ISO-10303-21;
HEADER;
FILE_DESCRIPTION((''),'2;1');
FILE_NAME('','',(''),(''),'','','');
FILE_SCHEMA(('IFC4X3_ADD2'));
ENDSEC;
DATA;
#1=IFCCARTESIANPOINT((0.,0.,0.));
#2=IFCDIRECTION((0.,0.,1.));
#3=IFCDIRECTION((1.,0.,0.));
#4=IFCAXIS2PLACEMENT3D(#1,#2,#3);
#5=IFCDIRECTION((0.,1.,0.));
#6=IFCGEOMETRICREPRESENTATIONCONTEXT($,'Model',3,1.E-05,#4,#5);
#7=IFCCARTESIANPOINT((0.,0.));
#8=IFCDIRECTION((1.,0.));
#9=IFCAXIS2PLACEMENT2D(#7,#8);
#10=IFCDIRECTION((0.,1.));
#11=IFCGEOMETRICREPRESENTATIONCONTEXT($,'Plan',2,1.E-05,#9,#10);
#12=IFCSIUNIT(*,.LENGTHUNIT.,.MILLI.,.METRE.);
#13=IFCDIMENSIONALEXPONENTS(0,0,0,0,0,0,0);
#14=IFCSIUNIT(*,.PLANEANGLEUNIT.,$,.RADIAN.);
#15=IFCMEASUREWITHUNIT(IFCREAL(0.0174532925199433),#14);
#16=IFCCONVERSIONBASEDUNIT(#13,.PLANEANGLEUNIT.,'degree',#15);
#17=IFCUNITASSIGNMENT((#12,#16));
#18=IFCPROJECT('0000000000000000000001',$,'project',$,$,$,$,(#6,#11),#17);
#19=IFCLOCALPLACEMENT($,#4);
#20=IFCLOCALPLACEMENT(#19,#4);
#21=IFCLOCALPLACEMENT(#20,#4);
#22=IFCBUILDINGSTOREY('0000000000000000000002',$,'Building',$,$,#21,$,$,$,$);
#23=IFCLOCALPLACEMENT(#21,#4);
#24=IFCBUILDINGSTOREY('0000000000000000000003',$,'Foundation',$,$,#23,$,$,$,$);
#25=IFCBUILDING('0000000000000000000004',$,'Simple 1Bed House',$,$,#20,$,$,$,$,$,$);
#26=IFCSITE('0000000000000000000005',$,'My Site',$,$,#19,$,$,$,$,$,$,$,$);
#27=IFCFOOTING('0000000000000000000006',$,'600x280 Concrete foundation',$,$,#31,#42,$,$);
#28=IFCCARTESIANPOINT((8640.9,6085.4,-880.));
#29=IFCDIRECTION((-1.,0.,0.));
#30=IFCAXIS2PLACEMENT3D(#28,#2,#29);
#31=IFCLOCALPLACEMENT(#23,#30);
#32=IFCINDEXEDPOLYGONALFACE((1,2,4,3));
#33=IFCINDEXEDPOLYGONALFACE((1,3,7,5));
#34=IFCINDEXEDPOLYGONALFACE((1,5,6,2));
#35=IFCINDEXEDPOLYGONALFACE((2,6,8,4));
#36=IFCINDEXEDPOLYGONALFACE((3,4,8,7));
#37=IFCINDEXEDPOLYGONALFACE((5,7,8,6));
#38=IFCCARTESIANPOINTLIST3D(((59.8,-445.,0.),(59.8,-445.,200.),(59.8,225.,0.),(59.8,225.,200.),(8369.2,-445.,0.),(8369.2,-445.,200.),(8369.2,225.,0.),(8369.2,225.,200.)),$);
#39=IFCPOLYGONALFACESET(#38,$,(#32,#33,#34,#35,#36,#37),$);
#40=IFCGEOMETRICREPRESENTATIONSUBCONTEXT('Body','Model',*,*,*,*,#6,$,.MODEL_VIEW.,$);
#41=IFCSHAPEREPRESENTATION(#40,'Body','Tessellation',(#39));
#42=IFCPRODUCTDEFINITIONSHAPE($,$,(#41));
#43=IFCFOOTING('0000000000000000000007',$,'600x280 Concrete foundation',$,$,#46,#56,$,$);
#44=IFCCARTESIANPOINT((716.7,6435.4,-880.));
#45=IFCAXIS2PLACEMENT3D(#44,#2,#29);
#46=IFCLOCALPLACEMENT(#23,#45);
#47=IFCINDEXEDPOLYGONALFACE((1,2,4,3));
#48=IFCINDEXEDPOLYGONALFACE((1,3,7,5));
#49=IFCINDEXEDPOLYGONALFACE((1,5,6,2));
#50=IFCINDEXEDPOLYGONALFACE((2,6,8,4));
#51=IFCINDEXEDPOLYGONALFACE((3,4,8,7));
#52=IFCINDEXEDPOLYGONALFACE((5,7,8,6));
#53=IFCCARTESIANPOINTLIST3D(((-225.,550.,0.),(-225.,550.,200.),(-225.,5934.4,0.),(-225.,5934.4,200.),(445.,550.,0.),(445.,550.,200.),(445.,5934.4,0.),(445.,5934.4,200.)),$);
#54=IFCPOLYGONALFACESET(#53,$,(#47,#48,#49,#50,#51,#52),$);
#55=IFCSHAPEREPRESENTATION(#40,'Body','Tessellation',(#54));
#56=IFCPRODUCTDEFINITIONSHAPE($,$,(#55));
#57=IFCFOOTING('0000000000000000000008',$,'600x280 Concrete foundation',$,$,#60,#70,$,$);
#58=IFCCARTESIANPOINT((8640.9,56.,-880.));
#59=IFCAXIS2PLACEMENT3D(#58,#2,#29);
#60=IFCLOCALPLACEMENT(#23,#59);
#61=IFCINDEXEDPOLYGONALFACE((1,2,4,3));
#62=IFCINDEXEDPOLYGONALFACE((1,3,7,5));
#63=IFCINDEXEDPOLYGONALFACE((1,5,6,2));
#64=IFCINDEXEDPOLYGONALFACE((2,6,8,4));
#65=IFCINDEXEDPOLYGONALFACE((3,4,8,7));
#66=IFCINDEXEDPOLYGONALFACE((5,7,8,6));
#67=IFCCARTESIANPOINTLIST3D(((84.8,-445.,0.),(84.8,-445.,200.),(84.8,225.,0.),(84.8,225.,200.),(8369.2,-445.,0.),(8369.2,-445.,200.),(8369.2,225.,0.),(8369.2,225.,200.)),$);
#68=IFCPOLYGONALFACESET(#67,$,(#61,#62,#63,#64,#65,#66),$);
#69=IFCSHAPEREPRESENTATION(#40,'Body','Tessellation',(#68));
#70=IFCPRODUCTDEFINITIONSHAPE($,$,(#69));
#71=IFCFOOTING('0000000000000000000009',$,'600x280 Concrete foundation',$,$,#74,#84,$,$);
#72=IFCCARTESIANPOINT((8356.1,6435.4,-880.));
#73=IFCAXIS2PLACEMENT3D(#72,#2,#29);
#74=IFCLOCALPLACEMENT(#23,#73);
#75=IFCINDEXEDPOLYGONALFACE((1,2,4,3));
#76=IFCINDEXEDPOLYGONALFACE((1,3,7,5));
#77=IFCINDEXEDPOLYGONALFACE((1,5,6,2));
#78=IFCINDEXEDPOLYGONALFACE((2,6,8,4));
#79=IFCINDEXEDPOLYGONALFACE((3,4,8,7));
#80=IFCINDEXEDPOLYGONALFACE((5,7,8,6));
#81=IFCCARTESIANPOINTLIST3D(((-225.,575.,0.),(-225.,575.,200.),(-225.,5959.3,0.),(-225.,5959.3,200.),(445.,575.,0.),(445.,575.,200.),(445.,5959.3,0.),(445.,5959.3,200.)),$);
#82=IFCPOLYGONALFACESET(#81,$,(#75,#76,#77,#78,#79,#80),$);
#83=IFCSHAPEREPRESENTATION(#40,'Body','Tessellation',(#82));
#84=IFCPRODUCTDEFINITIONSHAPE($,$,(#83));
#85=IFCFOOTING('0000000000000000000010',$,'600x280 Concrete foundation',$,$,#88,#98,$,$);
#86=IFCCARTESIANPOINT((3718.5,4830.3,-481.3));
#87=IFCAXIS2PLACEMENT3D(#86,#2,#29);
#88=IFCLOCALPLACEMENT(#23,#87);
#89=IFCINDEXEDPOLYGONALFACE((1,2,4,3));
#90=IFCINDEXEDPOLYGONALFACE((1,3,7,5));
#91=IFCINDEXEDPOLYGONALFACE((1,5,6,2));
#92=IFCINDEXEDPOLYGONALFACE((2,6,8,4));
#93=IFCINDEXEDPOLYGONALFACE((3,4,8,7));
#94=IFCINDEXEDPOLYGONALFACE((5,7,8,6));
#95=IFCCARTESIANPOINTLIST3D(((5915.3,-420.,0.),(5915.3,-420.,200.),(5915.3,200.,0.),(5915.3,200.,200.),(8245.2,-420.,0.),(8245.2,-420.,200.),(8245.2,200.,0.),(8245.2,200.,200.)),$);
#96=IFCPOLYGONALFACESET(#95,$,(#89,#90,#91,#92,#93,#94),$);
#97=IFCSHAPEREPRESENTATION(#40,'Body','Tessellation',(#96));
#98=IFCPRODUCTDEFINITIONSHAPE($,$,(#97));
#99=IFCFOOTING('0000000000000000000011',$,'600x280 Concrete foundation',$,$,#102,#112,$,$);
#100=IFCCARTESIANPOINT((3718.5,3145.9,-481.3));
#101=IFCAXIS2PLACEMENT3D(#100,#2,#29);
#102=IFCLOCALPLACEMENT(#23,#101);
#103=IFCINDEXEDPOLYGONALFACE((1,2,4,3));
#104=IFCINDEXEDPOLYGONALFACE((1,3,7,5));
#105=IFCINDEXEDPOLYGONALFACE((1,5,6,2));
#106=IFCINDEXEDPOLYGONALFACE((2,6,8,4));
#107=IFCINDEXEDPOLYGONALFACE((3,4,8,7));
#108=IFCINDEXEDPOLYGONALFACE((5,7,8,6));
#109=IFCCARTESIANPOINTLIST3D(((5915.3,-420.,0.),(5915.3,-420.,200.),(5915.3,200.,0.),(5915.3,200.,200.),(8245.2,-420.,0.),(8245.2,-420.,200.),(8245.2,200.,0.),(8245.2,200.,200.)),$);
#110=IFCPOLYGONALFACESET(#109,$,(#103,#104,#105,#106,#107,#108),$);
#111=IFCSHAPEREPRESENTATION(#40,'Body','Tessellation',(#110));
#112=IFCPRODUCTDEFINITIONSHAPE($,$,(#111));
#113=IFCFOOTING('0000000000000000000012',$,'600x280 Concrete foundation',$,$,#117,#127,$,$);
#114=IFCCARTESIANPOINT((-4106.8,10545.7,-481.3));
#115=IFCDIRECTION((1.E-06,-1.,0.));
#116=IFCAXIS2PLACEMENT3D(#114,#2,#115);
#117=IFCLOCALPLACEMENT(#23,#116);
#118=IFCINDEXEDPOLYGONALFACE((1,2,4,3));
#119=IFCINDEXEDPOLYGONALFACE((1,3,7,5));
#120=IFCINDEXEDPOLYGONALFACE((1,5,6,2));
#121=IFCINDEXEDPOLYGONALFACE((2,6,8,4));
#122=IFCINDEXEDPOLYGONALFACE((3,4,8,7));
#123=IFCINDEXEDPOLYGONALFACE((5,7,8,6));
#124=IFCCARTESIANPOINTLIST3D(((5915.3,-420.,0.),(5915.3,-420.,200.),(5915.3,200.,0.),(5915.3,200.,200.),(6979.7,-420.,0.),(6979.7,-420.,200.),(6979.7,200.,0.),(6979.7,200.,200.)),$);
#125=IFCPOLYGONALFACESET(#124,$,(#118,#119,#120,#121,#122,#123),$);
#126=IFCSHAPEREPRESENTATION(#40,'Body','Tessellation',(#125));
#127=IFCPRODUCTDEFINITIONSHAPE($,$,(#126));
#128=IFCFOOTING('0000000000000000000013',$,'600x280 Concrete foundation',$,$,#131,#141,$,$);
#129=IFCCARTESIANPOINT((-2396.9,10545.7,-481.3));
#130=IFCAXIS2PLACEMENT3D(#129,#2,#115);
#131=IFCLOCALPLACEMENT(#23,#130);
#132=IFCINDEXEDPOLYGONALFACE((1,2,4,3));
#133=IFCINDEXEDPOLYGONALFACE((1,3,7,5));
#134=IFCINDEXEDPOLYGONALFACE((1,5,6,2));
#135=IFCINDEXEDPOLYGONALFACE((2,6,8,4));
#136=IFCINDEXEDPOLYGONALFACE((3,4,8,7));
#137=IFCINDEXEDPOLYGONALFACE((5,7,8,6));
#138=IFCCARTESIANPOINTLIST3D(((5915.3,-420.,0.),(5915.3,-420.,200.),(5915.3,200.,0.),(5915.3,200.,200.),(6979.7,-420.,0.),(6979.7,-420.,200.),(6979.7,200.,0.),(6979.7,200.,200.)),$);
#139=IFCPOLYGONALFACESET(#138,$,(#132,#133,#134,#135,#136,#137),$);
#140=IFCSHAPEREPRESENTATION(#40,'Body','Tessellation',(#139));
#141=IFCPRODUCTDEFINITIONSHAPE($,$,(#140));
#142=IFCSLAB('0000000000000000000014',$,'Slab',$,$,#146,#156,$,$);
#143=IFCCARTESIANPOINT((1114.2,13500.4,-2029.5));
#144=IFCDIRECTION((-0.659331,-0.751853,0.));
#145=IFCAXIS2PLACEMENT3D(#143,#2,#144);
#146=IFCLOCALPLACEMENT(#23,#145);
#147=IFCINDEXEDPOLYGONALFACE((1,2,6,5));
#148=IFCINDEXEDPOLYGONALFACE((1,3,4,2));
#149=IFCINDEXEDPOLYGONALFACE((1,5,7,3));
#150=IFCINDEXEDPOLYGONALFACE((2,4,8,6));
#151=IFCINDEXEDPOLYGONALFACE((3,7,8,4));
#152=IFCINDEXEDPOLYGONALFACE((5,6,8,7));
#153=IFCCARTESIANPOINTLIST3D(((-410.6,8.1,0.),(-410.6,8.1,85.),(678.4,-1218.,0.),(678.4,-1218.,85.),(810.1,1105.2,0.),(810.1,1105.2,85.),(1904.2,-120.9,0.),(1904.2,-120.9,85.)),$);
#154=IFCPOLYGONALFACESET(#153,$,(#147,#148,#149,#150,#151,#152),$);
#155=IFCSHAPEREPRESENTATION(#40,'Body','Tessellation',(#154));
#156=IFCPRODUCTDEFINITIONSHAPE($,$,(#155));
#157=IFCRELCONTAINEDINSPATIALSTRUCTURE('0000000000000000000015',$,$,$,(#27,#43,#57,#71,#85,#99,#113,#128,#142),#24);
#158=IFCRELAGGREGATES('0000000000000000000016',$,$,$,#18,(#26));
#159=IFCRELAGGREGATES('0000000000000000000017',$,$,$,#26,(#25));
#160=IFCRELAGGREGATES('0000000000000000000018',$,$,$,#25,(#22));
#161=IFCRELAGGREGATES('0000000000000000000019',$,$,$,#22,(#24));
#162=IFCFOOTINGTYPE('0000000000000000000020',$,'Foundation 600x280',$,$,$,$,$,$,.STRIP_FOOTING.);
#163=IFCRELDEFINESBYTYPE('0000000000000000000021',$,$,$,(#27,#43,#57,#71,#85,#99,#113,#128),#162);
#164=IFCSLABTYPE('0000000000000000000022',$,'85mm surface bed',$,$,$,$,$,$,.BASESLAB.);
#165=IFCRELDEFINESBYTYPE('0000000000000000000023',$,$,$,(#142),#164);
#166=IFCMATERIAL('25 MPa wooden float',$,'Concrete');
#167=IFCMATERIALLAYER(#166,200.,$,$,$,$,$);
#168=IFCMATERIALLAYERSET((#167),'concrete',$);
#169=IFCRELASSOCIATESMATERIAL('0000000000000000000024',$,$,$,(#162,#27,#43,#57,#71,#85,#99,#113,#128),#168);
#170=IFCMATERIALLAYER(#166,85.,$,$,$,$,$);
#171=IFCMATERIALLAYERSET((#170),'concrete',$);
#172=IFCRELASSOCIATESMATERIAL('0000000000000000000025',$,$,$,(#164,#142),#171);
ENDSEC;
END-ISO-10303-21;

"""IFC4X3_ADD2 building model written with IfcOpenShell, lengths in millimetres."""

from ifc_helpers import new_model, entity, si_unit, converted_unit, direction, frame, origin_with_axes, origin_2d_with_axis, place, context, subcontext, project, spatial, indexed_curve, outline, extrude, material, layer, layer_set, layer_usage, type_object, element, save


model = new_model("IFC4X3_ADD2")

# Units and contexts
model_context = context("Model", 3, precision=1e-05, world=origin_with_axes(), true_north=direction((0.0, 1.0, 0.0)))
plan_context = context("Plan", 2, precision=1e-05, world=origin_2d_with_axis(), true_north=direction((0.0, 1.0)))
body_context = subcontext(model_context, "Body", "Model", "MODEL_VIEW")
ifc_project = project(units=[si_unit("LENGTHUNIT", "METRE", prefix="MILLI"), converted_unit("PLANEANGLEUNIT", "degree", entity("IfcReal", 0.0174532925199433), si_unit("PLANEANGLEUNIT", "RADIAN"), dimensions=[0, 0, 0, 0, 0, 0, 0])], contexts=[model_context, plan_context])

# Site, building, storeys
site_placement = place(None, origin_with_axes())
site = spatial("IfcSite", under=ifc_project, at=site_placement, Name="My Site")
building_placement = place(site_placement, origin_with_axes())
building = spatial("IfcBuilding", under=site, at=building_placement, Name="Simple 1Bed House")
storey_1_placement = place(building_placement, origin_with_axes())
storey_1 = spatial("IfcBuildingStorey", under=building, at=storey_1_placement, Name="Building")
storey_2_placement = place(storey_1_placement, origin_with_axes())
storey_2 = spatial("IfcBuildingStorey", under=storey_1, at=storey_2_placement, Name="Foundation")

# Footings
ifc_material_1 = material(Name="25 MPa wooden float", Category="Concrete")
ifc_layer_1 = layer(ifc_material_1, 200.0)
ifc_layer_set_1 = layer_set([ifc_layer_1], Name="concrete")
ifc_layer_usage_1 = layer_usage(ifc_layer_set_1, "AXIS3", "POSITIVE", 0.0)
footing_type = type_object("IfcFootingType", Name="Foundation 600x280", PredefinedType="STRIP_FOOTING", material=ifc_layer_set_1)
footing_1_placement = place(storey_2_placement, frame((8640.9, 6085.4, -880.0), z_axis=(0.0, 0.0, 1.0), x_axis=(-1.0, 0.0, 0.0)))
element("IfcFooting", 1, at=footing_1_placement, inside=storey_2, type_object=footing_type, material=ifc_layer_usage_1, Name="600x280 Concrete foundation", context=body_context, shape_type="SolidModel", body=[
    extrude(outline(indexed_curve([(8369.2, -445.0), (59.8, -445.0), (59.8, 225.0), (8369.2, 225.0), (8369.2, -445.0)])), None, (0.0, 0.0, 1.0), 200.0),
])
ifc_layer_usage_2 = layer_usage(ifc_layer_set_1, "AXIS3", "POSITIVE", 0.0)
footing_2_placement = place(storey_2_placement, frame((716.7, 6435.4, -880.0), z_axis=(0.0, 0.0, 1.0), x_axis=(-1.0, 0.0, 0.0)))
element("IfcFooting", 2, at=footing_2_placement, inside=storey_2, type_object=footing_type, material=ifc_layer_usage_2, Name="600x280 Concrete foundation", context=body_context, shape_type="SolidModel", body=[
    extrude(outline(indexed_curve([(445.0, 5934.4), (445.0, 550.0), (-225.0, 550.0), (-225.0, 5934.4), (445.0, 5934.4)])), None, (0.0, 0.0, 1.0), 200.0),
])
ifc_layer_usage_3 = layer_usage(ifc_layer_set_1, "AXIS3", "POSITIVE", 0.0)
footing_3_placement = place(storey_2_placement, frame((8640.9, 56.0, -880.0), z_axis=(0.0, 0.0, 1.0), x_axis=(-1.0, 0.0, 0.0)))
element("IfcFooting", 3, at=footing_3_placement, inside=storey_2, type_object=footing_type, material=ifc_layer_usage_3, Name="600x280 Concrete foundation", context=body_context, shape_type="SolidModel", body=[
    extrude(outline(indexed_curve([(84.8, -445.0), (84.8, 225.0), (8369.2, 225.0), (8369.2, -445.0), (84.8, -445.0)])), None, (0.0, 0.0, 1.0), 200.0),
])
ifc_layer_usage_4 = layer_usage(ifc_layer_set_1, "AXIS3", "POSITIVE", 0.0)
footing_4_placement = place(storey_2_placement, frame((8356.1, 6435.4, -880.0), z_axis=(0.0, 0.0, 1.0), x_axis=(-1.0, 0.0, 0.0)))
element("IfcFooting", 4, at=footing_4_placement, inside=storey_2, type_object=footing_type, material=ifc_layer_usage_4, Name="600x280 Concrete foundation", context=body_context, shape_type="SolidModel", body=[
    extrude(outline(indexed_curve([(445.0, 5959.3), (445.0, 575.0), (-225.0, 575.0), (-225.0, 5959.3), (445.0, 5959.3)])), None, (0.0, 0.0, 1.0), 200.0),
])
ifc_layer_usage_5 = layer_usage(ifc_layer_set_1, "AXIS3", "POSITIVE", 0.0)
footing_5_placement = place(storey_2_placement, frame((3718.5, 4830.3, -481.3), z_axis=(0.0, 0.0, 1.0), x_axis=(-1.0, 0.0, 0.0)))
element("IfcFooting", 5, at=footing_5_placement, inside=storey_2, type_object=footing_type, material=ifc_layer_usage_5, Name="600x280 Concrete foundation", context=body_context, shape_type="SweptSolid", body=[
    extrude(outline(indexed_curve([(8245.2, 200.0), (5915.3, 200.0), (5915.3, -420.0), (8245.2, -420.0), (8245.2, 200.0)])), None, (0.0, 0.0, 1.0), 200.0),
])
ifc_layer_usage_6 = layer_usage(ifc_layer_set_1, "AXIS3", "POSITIVE", 0.0)
footing_6_placement = place(storey_2_placement, frame((3718.5, 3145.9, -481.3), z_axis=(0.0, 0.0, 1.0), x_axis=(-1.0, 0.0, 0.0)))
element("IfcFooting", 6, at=footing_6_placement, inside=storey_2, type_object=footing_type, material=ifc_layer_usage_6, Name="600x280 Concrete foundation", context=body_context, shape_type="SweptSolid", body=[
    extrude(outline(indexed_curve([(8245.2, 200.0), (5915.3, 200.0), (5915.3, -420.0), (8245.2, -420.0), (8245.2, 200.0)])), None, (0.0, 0.0, 1.0), 200.0),
])
ifc_layer_usage_7 = layer_usage(ifc_layer_set_1, "AXIS3", "POSITIVE", 0.0)
footing_7_placement = place(storey_2_placement, frame((-4106.8, 10545.7, -481.3), z_axis=(0.0, 0.0, 1.0), x_axis=(0.000001, -1.0, 0.0)))
element("IfcFooting", 7, at=footing_7_placement, inside=storey_2, type_object=footing_type, material=ifc_layer_usage_7, Name="600x280 Concrete foundation", context=body_context, shape_type="SweptSolid", body=[
    extrude(outline(indexed_curve([(6979.7, -420.0), (6979.7, 200.0), (5915.3, 200.0), (5915.3, -420.0), (6979.7, -420.0)])), None, (0.0, 0.0, 1.0), 200.0),
])
ifc_layer_usage_8 = layer_usage(ifc_layer_set_1, "AXIS3", "POSITIVE", 0.0)
footing_8_placement = place(storey_2_placement, frame((-2396.9, 10545.7, -481.3), z_axis=(0.0, 0.0, 1.0), x_axis=(0.000001, -1.0, 0.0)))
element("IfcFooting", 8, at=footing_8_placement, inside=storey_2, type_object=footing_type, material=ifc_layer_usage_8, Name="600x280 Concrete foundation", context=body_context, shape_type="SweptSolid", body=[
    extrude(outline(indexed_curve([(6979.7, -420.0), (6979.7, 200.0), (5915.3, 200.0), (5915.3, -420.0), (6979.7, -420.0)])), None, (0.0, 0.0, 1.0), 200.0),
])

# Slab
ifc_layer_2 = layer(ifc_material_1, 85.0)
ifc_layer_set_2 = layer_set([ifc_layer_2], Name="concrete")
ifc_layer_usage_9 = layer_usage(ifc_layer_set_2, "AXIS3", "POSITIVE", 0.0)
slab_type = type_object("IfcSlabType", Name="85mm surface bed", PredefinedType="BASESLAB", material=ifc_layer_set_2)
slab_placement = place(storey_2_placement, frame((1114.2, 13500.4, -2029.5), z_axis=(0.0, 0.0, 1.0), x_axis=(-0.659331, -0.751853, 0.0)))
element("IfcSlab", 9, at=slab_placement, inside=storey_2, type_object=slab_type, material=ifc_layer_usage_9, Name="Slab", context=body_context, shape_type="SweptSolid", body=[
    extrude(outline(indexed_curve([(-410.6, 8.1), (810.1, 1105.2), (1904.2, -120.9), (678.4, -1218.0), (-410.6, 8.1)])), None, (0.0, 0.0, 1.0), 85.0),
])

save(model, "model.ifc")
